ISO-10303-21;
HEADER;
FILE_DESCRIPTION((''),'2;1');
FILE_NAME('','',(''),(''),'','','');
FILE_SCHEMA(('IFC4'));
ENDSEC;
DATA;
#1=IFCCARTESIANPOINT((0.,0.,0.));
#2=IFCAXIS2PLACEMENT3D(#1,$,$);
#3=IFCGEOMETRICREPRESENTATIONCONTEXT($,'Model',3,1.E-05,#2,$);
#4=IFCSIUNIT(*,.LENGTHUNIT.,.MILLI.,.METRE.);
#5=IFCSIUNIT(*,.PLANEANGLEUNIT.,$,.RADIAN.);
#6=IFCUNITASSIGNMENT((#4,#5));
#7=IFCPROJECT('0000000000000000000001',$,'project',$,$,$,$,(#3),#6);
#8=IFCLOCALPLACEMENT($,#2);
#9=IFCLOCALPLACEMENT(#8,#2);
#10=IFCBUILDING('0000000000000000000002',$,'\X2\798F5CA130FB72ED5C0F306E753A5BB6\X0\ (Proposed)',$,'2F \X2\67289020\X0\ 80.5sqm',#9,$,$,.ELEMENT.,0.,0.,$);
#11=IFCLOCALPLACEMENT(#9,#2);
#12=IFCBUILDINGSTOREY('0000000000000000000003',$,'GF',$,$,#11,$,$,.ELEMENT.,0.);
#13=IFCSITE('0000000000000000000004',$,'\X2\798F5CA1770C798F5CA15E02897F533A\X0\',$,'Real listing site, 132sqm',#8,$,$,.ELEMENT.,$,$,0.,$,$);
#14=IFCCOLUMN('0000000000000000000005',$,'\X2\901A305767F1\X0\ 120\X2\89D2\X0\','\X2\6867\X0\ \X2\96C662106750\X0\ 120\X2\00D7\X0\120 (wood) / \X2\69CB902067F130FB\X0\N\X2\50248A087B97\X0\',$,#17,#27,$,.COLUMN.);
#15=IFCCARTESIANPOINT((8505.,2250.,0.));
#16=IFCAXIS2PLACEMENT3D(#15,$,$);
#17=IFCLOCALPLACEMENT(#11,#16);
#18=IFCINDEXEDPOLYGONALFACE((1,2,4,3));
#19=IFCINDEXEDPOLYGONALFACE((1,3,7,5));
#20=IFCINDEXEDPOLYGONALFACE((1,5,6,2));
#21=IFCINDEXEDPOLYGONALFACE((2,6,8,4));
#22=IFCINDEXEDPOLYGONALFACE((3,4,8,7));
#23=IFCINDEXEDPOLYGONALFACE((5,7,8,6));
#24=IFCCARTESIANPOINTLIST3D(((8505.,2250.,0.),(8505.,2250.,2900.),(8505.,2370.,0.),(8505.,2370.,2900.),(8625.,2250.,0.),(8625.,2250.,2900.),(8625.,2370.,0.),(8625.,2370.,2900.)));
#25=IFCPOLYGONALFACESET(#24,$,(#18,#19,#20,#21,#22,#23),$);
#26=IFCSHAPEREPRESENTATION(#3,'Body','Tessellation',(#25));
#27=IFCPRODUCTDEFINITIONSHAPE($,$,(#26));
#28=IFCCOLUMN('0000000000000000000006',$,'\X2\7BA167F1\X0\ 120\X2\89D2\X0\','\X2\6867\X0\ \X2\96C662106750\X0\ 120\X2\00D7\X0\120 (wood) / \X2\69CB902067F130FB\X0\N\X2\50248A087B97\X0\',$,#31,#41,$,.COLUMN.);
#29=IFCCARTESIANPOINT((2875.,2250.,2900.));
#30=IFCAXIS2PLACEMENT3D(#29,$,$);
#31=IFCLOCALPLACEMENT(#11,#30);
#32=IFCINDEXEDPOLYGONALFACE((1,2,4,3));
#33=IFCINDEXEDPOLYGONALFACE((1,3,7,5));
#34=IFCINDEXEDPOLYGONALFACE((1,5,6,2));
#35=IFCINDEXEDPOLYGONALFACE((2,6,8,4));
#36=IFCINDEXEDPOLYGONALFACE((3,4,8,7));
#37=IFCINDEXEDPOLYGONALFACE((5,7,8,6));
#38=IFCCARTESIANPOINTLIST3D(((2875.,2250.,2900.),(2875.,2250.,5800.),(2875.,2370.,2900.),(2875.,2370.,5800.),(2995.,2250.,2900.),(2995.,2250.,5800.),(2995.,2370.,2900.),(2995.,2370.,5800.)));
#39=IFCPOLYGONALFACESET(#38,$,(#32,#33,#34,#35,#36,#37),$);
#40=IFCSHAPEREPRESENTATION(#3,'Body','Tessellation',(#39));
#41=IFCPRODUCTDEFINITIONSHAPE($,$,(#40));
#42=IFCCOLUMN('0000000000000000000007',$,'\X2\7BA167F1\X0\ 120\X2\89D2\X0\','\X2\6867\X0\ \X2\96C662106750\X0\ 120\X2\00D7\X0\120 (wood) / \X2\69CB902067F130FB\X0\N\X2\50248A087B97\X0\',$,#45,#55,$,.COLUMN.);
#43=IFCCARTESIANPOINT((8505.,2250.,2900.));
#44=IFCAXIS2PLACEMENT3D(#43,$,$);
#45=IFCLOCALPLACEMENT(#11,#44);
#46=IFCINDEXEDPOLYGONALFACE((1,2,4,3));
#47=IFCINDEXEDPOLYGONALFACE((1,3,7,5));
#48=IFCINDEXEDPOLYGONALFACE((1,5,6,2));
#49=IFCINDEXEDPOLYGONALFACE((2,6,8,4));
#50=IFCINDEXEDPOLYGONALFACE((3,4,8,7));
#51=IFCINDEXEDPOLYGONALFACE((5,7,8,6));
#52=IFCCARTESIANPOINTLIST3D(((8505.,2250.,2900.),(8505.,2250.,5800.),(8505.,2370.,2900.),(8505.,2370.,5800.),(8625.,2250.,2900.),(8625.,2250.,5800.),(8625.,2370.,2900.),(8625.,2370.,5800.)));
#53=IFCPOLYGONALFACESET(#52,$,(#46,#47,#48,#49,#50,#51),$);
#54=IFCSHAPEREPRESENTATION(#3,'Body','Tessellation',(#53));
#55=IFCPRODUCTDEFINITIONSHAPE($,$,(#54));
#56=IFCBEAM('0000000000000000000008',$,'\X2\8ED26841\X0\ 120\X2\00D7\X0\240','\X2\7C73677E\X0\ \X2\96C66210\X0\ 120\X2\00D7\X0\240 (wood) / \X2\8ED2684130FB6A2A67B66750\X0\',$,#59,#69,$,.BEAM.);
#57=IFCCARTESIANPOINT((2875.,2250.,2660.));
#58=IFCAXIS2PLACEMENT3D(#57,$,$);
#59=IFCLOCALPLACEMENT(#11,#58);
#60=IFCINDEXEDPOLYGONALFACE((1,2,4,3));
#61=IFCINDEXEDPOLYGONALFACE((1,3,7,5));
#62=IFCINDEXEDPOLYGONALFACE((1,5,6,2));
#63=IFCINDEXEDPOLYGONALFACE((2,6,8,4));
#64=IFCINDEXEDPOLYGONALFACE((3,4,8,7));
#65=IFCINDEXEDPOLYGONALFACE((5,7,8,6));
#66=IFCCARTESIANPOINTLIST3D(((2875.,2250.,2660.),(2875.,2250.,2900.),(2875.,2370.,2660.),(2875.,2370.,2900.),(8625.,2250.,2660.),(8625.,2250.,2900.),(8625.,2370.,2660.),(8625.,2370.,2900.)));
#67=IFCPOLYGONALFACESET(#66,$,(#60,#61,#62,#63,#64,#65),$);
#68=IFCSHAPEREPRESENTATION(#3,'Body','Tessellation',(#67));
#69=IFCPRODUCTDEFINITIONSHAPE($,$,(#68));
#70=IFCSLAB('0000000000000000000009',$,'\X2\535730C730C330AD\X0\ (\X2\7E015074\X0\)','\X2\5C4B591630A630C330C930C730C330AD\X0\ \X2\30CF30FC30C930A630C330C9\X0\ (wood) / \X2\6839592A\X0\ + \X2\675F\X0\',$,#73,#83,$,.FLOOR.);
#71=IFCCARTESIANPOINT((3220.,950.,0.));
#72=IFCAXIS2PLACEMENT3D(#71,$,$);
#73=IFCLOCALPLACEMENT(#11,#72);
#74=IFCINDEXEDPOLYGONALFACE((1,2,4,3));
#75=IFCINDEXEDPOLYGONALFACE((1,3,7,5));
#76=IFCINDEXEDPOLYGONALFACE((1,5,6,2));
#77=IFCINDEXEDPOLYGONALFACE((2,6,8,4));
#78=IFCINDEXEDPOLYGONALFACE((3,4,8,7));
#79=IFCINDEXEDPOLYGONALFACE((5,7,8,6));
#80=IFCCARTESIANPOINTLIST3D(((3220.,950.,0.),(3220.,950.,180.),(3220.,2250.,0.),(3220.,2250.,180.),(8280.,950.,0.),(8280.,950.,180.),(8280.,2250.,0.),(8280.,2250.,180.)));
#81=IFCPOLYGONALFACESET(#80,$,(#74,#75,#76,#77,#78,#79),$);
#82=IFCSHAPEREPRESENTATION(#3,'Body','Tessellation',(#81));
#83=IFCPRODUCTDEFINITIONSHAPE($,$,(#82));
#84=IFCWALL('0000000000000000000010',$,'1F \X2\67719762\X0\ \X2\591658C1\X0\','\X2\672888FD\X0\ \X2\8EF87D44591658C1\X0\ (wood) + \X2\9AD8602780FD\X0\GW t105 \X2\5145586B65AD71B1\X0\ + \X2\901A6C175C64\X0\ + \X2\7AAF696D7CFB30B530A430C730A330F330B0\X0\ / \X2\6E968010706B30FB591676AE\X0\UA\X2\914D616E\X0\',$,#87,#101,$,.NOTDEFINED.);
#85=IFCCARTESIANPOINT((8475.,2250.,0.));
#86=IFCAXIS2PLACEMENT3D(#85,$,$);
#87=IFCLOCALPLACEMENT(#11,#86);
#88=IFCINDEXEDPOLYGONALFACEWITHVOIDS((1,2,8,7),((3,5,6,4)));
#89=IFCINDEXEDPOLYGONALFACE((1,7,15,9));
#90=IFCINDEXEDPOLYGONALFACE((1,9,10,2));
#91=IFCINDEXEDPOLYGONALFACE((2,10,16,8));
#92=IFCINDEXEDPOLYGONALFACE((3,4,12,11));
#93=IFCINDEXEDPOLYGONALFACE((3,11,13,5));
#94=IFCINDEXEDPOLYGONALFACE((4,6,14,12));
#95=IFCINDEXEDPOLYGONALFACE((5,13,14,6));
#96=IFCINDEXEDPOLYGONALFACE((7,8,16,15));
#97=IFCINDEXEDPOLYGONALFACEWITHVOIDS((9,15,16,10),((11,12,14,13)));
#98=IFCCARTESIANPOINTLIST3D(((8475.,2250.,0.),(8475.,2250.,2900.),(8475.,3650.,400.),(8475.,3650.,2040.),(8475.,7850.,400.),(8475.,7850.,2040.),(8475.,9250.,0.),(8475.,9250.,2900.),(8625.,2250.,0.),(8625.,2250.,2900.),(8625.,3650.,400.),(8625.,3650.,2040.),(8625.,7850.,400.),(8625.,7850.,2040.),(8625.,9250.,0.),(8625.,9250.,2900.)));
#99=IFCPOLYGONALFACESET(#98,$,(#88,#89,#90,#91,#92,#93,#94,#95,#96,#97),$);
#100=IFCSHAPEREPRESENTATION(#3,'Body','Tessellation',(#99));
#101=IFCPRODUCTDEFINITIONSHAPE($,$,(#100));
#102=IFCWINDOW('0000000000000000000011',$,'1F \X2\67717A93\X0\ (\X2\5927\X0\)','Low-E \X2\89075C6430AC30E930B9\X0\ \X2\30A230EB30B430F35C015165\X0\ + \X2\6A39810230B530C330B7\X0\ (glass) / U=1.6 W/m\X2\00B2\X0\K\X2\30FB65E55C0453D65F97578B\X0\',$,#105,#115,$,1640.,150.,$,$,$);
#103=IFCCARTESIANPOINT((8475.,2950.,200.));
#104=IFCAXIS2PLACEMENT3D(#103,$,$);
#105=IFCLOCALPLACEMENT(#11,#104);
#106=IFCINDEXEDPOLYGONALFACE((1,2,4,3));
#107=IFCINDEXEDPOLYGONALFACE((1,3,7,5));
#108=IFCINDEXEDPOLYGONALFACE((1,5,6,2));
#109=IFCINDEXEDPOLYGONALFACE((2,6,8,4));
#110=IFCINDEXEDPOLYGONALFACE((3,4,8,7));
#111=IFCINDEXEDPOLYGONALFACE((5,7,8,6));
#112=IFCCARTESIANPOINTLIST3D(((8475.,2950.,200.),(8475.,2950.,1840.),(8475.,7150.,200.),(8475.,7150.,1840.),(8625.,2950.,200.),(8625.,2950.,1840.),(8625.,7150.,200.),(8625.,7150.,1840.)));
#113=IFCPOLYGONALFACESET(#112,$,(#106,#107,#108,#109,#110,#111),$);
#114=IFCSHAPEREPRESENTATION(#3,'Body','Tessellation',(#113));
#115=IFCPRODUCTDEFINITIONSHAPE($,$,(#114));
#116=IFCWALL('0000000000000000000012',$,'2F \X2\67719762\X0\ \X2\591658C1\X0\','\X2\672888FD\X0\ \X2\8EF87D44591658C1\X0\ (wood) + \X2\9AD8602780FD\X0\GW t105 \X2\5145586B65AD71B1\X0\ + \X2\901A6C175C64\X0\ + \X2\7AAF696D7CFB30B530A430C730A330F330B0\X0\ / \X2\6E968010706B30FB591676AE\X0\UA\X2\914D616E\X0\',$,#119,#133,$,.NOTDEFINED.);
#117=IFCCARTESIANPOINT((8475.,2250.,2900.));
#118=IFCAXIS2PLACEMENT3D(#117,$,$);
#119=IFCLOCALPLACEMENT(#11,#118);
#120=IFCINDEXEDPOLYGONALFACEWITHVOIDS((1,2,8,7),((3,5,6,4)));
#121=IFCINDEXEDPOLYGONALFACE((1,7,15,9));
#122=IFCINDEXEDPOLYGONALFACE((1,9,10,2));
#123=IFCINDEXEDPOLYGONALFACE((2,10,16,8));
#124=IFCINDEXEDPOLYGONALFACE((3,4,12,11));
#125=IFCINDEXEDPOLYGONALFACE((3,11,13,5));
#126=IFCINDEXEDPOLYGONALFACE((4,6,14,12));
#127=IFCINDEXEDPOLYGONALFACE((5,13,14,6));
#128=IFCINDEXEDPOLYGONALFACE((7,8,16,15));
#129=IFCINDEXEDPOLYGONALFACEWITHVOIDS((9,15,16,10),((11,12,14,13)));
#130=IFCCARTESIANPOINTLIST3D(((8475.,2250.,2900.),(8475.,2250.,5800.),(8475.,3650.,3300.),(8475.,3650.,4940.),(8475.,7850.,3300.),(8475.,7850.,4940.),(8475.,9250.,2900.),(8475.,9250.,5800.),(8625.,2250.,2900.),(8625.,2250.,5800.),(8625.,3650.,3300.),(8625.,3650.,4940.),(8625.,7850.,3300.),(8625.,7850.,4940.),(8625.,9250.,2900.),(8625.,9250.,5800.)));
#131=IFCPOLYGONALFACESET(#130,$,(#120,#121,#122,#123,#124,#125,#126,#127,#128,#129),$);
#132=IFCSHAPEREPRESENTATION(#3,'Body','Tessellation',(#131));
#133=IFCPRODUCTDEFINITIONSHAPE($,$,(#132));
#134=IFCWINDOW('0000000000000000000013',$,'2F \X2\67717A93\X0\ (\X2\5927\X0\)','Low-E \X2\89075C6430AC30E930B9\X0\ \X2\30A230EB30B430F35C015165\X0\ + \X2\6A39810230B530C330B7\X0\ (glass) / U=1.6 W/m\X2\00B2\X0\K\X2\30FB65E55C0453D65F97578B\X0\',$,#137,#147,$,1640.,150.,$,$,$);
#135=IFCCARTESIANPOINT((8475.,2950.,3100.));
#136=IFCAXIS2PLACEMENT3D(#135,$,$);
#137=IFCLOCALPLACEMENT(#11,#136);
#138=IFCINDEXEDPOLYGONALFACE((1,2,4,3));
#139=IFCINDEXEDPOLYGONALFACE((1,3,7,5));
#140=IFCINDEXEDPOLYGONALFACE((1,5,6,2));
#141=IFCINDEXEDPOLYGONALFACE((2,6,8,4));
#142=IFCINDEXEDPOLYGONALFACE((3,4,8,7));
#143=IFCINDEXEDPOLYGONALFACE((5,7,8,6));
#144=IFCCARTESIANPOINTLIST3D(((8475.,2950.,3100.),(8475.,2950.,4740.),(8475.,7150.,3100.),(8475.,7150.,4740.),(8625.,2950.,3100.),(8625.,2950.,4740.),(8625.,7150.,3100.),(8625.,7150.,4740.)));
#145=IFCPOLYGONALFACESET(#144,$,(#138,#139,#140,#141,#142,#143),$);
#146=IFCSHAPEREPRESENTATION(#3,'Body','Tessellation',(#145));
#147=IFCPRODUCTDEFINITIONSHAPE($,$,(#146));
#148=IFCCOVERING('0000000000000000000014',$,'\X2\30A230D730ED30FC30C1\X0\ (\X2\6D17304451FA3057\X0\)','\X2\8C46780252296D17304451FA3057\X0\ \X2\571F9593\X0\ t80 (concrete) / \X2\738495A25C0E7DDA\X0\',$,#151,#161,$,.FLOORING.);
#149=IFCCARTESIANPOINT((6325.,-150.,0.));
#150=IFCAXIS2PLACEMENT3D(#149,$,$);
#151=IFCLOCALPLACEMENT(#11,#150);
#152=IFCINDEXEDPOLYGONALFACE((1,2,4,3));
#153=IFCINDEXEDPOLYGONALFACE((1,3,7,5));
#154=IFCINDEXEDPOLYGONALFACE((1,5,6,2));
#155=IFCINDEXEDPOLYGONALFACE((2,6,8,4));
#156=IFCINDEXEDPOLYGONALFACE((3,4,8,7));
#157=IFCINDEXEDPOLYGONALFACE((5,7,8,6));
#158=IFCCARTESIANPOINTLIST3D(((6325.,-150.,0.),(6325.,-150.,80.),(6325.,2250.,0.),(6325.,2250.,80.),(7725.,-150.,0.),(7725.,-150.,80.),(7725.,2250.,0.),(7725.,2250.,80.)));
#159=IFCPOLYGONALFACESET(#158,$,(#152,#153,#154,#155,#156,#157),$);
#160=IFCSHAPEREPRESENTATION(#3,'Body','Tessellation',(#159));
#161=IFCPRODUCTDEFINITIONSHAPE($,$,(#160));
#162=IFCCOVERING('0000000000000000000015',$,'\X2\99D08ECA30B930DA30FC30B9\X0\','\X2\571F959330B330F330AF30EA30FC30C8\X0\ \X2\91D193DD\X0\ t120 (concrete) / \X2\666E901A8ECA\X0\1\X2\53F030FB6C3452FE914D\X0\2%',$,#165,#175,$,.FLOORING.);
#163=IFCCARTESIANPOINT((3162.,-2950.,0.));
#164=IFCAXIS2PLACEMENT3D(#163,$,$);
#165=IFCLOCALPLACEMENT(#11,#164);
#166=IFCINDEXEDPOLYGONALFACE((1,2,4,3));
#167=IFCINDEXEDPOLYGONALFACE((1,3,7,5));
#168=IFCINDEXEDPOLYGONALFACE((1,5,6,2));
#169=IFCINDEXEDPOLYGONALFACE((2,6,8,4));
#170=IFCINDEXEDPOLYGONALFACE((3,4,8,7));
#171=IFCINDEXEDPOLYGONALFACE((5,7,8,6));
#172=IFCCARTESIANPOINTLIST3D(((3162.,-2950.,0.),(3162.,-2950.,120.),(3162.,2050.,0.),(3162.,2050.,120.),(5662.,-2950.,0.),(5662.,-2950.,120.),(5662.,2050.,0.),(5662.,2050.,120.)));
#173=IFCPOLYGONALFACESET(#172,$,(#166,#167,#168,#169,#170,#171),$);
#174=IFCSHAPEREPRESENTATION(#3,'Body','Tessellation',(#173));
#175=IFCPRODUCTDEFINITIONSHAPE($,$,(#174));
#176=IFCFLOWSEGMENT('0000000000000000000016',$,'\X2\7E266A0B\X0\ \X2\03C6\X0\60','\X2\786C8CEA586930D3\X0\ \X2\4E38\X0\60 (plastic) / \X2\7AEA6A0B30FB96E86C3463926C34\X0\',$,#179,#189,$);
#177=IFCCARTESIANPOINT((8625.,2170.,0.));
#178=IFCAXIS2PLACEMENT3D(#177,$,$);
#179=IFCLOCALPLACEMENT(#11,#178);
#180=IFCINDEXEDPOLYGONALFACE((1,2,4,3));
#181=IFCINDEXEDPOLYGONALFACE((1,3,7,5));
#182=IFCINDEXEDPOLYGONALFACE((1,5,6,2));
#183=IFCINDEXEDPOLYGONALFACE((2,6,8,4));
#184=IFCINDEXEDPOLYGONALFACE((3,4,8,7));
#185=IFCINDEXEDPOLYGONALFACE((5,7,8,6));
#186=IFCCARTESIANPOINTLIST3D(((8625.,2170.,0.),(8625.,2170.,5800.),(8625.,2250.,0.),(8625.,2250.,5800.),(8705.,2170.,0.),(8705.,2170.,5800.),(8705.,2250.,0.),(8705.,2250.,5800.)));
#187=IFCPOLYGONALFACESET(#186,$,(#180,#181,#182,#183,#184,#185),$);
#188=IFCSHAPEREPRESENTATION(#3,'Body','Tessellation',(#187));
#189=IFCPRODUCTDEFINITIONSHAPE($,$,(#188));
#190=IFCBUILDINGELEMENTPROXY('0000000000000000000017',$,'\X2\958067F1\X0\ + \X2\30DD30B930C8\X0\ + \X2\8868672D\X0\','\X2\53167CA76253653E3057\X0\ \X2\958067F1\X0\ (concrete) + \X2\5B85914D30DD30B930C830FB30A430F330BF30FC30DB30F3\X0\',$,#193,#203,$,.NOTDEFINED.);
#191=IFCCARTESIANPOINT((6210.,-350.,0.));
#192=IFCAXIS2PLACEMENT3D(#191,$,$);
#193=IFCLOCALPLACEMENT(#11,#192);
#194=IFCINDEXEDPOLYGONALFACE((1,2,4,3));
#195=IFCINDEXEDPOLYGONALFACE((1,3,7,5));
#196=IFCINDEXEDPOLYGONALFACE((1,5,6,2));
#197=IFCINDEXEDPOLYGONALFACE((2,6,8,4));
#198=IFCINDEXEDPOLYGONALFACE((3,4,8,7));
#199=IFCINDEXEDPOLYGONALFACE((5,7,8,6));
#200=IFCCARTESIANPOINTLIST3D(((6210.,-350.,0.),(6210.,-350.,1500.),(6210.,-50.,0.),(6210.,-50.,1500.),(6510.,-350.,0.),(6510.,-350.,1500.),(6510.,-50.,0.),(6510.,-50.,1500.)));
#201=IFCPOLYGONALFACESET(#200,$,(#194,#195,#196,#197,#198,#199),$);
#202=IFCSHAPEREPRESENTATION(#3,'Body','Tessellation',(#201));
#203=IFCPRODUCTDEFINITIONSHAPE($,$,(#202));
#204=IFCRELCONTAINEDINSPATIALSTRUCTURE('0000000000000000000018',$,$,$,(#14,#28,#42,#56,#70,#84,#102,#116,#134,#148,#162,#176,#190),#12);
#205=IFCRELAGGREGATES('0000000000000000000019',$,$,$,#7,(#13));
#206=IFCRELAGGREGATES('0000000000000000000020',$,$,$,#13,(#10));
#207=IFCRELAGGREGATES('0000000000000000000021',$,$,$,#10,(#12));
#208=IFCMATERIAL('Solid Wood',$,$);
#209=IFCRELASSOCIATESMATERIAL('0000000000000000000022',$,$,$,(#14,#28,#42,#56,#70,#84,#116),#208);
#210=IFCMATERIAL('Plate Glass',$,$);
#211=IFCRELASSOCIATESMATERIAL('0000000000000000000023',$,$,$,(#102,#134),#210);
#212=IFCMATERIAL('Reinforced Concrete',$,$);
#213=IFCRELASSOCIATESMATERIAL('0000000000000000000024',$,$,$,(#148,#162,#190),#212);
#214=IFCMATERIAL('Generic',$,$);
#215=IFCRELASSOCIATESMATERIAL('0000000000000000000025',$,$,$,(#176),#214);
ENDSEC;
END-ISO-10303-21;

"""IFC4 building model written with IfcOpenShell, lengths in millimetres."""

from ifc_helpers import new_model, si_unit, frame, frame_2d, origin, place, context, project, spatial, rectangle, extrude, material, element, fill, save


model = new_model("IFC4")

# Units and contexts
model_context = context("Model", 3, precision=1e-05, world=origin())
ifc_project = project(units=[si_unit("LENGTHUNIT", "METRE", prefix="MILLI"), si_unit("PLANEANGLEUNIT", "RADIAN")], contexts=[model_context])

# Site, building, storey
site_placement = place(None, origin())
site = spatial("IfcSite", under=ifc_project, at=site_placement, Name="福岡県福岡市西区", ObjectType="Real listing site, 132sqm", CompositionType="ELEMENT", RefElevation=0.0)
building_placement = place(site_placement, origin())
building = spatial("IfcBuilding", under=site, at=building_placement, Name="福岡・狭小の町家 (Proposed)", ObjectType="2F 木造 80.5sqm", CompositionType="ELEMENT", ElevationOfRefHeight=0.0, ElevationOfTerrain=0.0)
storey_placement = place(building_placement, origin())
storey = spatial("IfcBuildingStorey", under=building, at=storey_placement, Name="GF", CompositionType="ELEMENT", Elevation=0.0)

# Columns
ifc_material_1 = material(Name="Solid Wood")
column_1_placement = place(storey_placement, frame((8505.0, 2250.0, 0.0)))
element("IfcColumn", 1, at=column_1_placement, inside=storey, material=ifc_material_1, Name="通し柱 120角", Description="桧 集成材 120×120 (wood) / 構造柱・N値計算", PredefinedType="COLUMN", context=model_context, shape_type="SweptSolid", body=[
    extrude(rectangle(XDim=120.0, YDim=120.0, at=frame_2d((60.0, 60.0))), frame((8505.0, 2250.0, 0.0)), (0.0, 0.0, 1.0), 2900.0),
])
column_2_placement = place(storey_placement, frame((2875.0, 2250.0, 2900.0)))
element("IfcColumn", 2, at=column_2_placement, inside=storey, material=ifc_material_1, Name="管柱 120角", Description="桧 集成材 120×120 (wood) / 構造柱・N値計算", PredefinedType="COLUMN", context=model_context, shape_type="SweptSolid", body=[
    extrude(rectangle(XDim=120.0, YDim=120.0, at=frame_2d((60.0, 60.0))), frame((2875.0, 2250.0, 2900.0)), (0.0, 0.0, 1.0), 2900.0),
])
column_3_placement = place(storey_placement, frame((8505.0, 2250.0, 2900.0)))
element("IfcColumn", 3, at=column_3_placement, inside=storey, material=ifc_material_1, Name="管柱 120角", Description="桧 集成材 120×120 (wood) / 構造柱・N値計算", PredefinedType="COLUMN", context=model_context, shape_type="SweptSolid", body=[
    extrude(rectangle(XDim=120.0, YDim=120.0, at=frame_2d((60.0, 60.0))), frame((8505.0, 2250.0, 2900.0)), (0.0, 0.0, 1.0), 2900.0),
])

# Beam
beam_1_placement = place(storey_placement, frame((2875.0, 2250.0, 2660.0)))
element("IfcBeam", 4, at=beam_1_placement, inside=storey, material=ifc_material_1, Name="軒桁 120×240", Description="米松 集成 120×240 (wood) / 軒桁・横架材", PredefinedType="BEAM", context=model_context, shape_type="SweptSolid", body=[
    extrude(rectangle(XDim=5750.0, YDim=120.0, at=frame_2d((2875.0, 60.0))), frame((2875.0, 2250.0, 2660.0)), (0.0, 0.0, 1.0), 240.0),
])

# Slab
slab_placement = place(storey_placement, frame((3220.0, 950.0, 0.0)))
element("IfcSlab", 5, at=slab_placement, inside=storey, material=ifc_material_1, Name="南デッキ (縁側)", Description="屋外ウッドデッキ ハードウッド (wood) / 根太 + 束", PredefinedType="FLOOR", context=model_context, shape_type="SweptSolid", body=[
    extrude(rectangle(XDim=5060.0, YDim=1300.0, at=frame_2d((2530.0, 650.0))), frame((3220.0, 950.0, 0.0)), (0.0, 0.0, 1.0), 180.0),
])

# Walls, openings, windows
wall_1_placement = place(storey_placement, frame((8475.0, 2250.0, 0.0)))
wall_1 = element("IfcWall", 6, at=wall_1_placement, inside=storey, material=ifc_material_1, Name="1F 東面 外壁", Description="木製 軸組外壁 (wood) + 高性能GW t105 充填断熱 + 通気層 + 窯業系サイディング / 準耐火・外皮UA配慮", PredefinedType="NOTDEFINED", context=model_context, shape_type="SweptSolid", body=[
    extrude(rectangle(XDim=150.0, YDim=7000.0, at=frame_2d((75.0, 3500.0))), frame((8475.0, 2250.0, 0.0)), (0.0, 0.0, 1.0), 2900.0),
])
opening_1_placement = place(storey_placement, frame((8475.0, 2950.0, 200.0)))
opening_1 = element("IfcOpeningElement", 7, at=opening_1_placement, cuts=wall_1, PredefinedType="NOTDEFINED", context=model_context, shape_type="SweptSolid", body=[
    extrude(rectangle(XDim=150.0, YDim=4200.0, at=frame_2d((75.0, 2100.0))), frame((8475.0, 2950.0, 200.0)), (0.0, 0.0, 1.0), 1640.0),
])
ifc_material_2 = material(Name="Plate Glass")
window_1_placement = place(storey_placement, frame((8475.0, 2950.0, 200.0)))
window_1 = element("IfcWindow", 8, at=window_1_placement, inside=storey, material=ifc_material_2, Name="1F 東窓 (大)", Description="Low-E 複層ガラス アルゴン封入 + 樹脂サッシ (glass) / U=1.6 W/m²K・日射取得型", OverallHeight=1640.0, OverallWidth=150.0, context=model_context, shape_type="SweptSolid", body=[
    extrude(rectangle(XDim=150.0, YDim=4200.0, at=frame_2d((75.0, 2100.0))), frame((8475.0, 2950.0, 200.0)), (0.0, 0.0, 1.0), 1640.0),
])
fill(opening_1, window_1)
wall_2_placement = place(storey_placement, frame((8475.0, 2250.0, 2900.0)))
wall_2 = element("IfcWall", 9, at=wall_2_placement, inside=storey, material=ifc_material_1, Name="2F 東面 外壁", Description="木製 軸組外壁 (wood) + 高性能GW t105 充填断熱 + 通気層 + 窯業系サイディング / 準耐火・外皮UA配慮", PredefinedType="NOTDEFINED", context=model_context, shape_type="SweptSolid", body=[
    extrude(rectangle(XDim=150.0, YDim=7000.0, at=frame_2d((75.0, 3500.0))), frame((8475.0, 2250.0, 2900.0)), (0.0, 0.0, 1.0), 2900.0),
])
opening_2_placement = place(storey_placement, frame((8475.0, 2950.0, 3100.0)))
opening_2 = element("IfcOpeningElement", 10, at=opening_2_placement, cuts=wall_2, PredefinedType="NOTDEFINED", context=model_context, shape_type="SweptSolid", body=[
    extrude(rectangle(XDim=150.0, YDim=4200.0, at=frame_2d((75.0, 2100.0))), frame((8475.0, 2950.0, 3100.0)), (0.0, 0.0, 1.0), 1640.0),
])
window_2_placement = place(storey_placement, frame((8475.0, 2950.0, 3100.0)))
window_2 = element("IfcWindow", 11, at=window_2_placement, inside=storey, material=ifc_material_2, Name="2F 東窓 (大)", Description="Low-E 複層ガラス アルゴン封入 + 樹脂サッシ (glass) / U=1.6 W/m²K・日射取得型", OverallHeight=1640.0, OverallWidth=150.0, context=model_context, shape_type="SweptSolid", body=[
    extrude(rectangle(XDim=150.0, YDim=4200.0, at=frame_2d((75.0, 2100.0))), frame((8475.0, 2950.0, 3100.0)), (0.0, 0.0, 1.0), 1640.0),
])
fill(opening_2, window_2)

# Coverings
ifc_material_3 = material(Name="Reinforced Concrete")
covering_1_placement = place(storey_placement, frame((6325.0, -150.0, 0.0)))
element("IfcCovering", 12, at=covering_1_placement, inside=storey, material=ifc_material_3, Name="アプローチ (洗い出し)", Description="豆砂利洗い出し 土間 t80 (concrete) / 玄関導線", PredefinedType="FLOORING", context=model_context, shape_type="SweptSolid", body=[
    extrude(rectangle(XDim=1400.0, YDim=2400.0, at=frame_2d((700.0, 1200.0))), frame((6325.0, -150.0, 0.0)), (0.0, 0.0, 1.0), 80.0),
])
covering_2_placement = place(storey_placement, frame((3162.0, -2950.0, 0.0)))
element("IfcCovering", 13, at=covering_2_placement, inside=storey, material=ifc_material_3, Name="駐車スペース", Description="土間コンクリート 金鏝 t120 (concrete) / 普通車1台・水勾配2%", PredefinedType="FLOORING", context=model_context, shape_type="SweptSolid", body=[
    extrude(rectangle(XDim=2500.0, YDim=5000.0, at=frame_2d((1250.0, 2500.0))), frame((3162.0, -2950.0, 0.0)), (0.0, 0.0, 1.0), 120.0),
])

# Flow segment
ifc_material_4 = material(Name="Generic")
flow_segment_placement = place(storey_placement, frame((8625.0, 2170.0, 0.0)))
element("IfcFlowSegment", 14, at=flow_segment_placement, inside=storey, material=ifc_material_4, Name="縦樋 φ60", Description="硬質塩ビ 丸60 (plastic) / 竪樋・雨水排水", context=model_context, shape_type="SweptSolid", body=[
    extrude(rectangle(XDim=80.0, YDim=80.0, at=frame_2d((40.0, 40.0))), frame((8625.0, 2170.0, 0.0)), (0.0, 0.0, 1.0), 5800.0),
])

# Building element proxy
proxy_placement = place(storey_placement, frame((6210.0, -350.0, 0.0)))
element("IfcBuildingElementProxy", 15, at=proxy_placement, inside=storey, material=ifc_material_3, Name="門柱 + ポスト + 表札", Description="化粧打放し 門柱 (concrete) + 宅配ポスト・インターホン", PredefinedType="NOTDEFINED", context=model_context, shape_type="SweptSolid", body=[
    extrude(rectangle(XDim=300.0, YDim=300.0, at=frame_2d((150.0, 150.0))), frame((6210.0, -350.0, 0.0)), (0.0, 0.0, 1.0), 1500.0),
])

save(model, "model.ifc")
